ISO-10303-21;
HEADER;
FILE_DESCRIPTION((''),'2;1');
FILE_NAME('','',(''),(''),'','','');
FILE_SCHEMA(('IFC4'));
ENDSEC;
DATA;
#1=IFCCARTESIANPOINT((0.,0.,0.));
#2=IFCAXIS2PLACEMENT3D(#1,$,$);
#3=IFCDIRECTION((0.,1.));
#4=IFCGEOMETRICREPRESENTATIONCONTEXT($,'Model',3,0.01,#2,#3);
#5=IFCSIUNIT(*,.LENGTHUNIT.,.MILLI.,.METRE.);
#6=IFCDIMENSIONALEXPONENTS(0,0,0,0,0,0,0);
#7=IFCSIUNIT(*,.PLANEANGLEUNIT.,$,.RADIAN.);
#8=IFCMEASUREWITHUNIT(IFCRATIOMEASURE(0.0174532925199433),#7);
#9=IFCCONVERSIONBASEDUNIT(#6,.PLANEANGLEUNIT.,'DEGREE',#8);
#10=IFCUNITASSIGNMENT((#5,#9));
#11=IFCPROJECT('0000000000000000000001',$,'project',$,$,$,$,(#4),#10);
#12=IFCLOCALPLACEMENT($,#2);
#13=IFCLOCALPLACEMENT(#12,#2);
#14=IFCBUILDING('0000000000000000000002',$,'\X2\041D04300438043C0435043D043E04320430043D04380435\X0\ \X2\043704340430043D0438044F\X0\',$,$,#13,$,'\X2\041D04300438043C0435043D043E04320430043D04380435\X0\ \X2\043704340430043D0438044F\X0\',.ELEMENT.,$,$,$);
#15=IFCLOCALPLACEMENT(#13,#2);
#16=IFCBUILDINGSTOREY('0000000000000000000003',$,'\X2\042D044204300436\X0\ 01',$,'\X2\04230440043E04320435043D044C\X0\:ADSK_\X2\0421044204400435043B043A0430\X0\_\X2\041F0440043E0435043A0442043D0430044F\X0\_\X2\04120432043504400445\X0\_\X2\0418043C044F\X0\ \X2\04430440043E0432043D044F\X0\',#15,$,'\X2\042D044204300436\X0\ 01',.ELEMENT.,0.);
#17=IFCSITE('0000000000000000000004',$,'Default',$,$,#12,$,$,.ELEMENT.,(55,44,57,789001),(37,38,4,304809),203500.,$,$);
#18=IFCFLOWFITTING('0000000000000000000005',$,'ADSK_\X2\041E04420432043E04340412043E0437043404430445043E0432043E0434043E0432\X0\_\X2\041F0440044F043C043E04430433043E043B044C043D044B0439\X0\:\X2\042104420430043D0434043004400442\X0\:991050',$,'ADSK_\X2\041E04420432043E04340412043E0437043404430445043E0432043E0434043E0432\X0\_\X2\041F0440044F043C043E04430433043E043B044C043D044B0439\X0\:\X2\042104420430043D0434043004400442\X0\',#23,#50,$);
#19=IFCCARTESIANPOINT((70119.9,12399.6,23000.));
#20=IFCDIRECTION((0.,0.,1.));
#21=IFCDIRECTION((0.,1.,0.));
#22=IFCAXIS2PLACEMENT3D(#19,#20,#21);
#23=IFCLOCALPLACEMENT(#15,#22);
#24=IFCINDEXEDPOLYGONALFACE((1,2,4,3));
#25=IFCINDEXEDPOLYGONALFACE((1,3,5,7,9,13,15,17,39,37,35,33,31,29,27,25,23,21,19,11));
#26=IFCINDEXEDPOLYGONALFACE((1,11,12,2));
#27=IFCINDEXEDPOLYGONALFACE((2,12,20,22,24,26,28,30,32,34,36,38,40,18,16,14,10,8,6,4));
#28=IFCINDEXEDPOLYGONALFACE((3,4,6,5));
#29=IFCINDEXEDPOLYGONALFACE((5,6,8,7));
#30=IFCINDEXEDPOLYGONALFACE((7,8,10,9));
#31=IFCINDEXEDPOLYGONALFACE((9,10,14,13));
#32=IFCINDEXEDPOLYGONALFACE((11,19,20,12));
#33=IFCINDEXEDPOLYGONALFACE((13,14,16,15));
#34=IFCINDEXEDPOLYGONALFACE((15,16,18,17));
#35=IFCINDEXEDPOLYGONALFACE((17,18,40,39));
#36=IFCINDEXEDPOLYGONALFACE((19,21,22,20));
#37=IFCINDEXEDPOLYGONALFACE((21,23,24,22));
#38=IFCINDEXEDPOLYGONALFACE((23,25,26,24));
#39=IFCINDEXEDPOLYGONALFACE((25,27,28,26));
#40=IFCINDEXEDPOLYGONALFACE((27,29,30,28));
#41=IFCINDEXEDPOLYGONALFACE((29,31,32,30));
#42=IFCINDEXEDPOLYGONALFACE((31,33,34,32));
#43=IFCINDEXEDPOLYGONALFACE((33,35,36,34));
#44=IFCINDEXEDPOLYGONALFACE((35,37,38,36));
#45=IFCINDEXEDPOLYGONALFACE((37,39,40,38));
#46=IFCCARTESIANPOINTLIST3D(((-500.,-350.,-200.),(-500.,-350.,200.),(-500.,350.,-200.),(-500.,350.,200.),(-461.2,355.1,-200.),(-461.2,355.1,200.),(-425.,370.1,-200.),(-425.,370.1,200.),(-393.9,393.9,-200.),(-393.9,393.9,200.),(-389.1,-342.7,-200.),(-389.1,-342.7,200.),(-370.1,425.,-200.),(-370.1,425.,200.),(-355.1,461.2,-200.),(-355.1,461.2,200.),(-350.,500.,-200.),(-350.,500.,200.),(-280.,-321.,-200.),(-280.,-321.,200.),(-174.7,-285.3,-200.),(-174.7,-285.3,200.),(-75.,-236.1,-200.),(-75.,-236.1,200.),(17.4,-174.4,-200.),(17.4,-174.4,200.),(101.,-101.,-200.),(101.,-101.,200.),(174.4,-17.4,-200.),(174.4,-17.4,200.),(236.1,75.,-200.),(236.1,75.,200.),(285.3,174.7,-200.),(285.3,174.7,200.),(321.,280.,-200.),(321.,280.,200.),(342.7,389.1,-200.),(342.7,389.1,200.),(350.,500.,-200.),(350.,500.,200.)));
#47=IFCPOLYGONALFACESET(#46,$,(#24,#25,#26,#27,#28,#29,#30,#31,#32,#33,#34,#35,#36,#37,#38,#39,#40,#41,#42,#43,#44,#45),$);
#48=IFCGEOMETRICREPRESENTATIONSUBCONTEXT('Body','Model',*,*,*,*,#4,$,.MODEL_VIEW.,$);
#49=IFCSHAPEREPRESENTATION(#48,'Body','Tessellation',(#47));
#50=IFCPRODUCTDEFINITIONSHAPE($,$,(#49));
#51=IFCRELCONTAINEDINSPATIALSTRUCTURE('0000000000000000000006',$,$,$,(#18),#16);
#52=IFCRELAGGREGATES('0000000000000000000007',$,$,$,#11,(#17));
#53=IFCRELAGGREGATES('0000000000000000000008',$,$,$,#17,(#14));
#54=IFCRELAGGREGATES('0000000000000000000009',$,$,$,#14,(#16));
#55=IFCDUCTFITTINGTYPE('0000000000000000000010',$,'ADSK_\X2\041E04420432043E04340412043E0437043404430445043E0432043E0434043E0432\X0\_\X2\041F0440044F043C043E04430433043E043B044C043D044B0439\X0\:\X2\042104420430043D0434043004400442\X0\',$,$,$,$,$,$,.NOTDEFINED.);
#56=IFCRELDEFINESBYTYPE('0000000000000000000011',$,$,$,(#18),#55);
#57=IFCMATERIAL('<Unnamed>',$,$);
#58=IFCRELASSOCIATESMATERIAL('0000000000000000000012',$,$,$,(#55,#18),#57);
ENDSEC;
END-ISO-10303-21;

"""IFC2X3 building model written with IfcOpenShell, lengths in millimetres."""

from ifc_helpers import new_model, entity, si_unit, converted_unit, direction, frame, frame_2d, origin, place, context, subcontext, project, spatial, polyline, circle_curve, parameter, trimmed, segment, composite_curve, outline, extrude, source, transform, mapped, material, type_object, type_shapes, element, save


model = new_model("IFC2X3")

# Units and contexts
model_context = context("Model", 3, precision=0.01, world=origin(), true_north=direction((0.0, 1.0)))
body_context = subcontext(model_context, "Body", "Model", "MODEL_VIEW")
ifc_project = project(units=[si_unit("LENGTHUNIT", "METRE", prefix="MILLI"), converted_unit("PLANEANGLEUNIT", "DEGREE", entity("IfcRatioMeasure", 0.0174532925199433), si_unit("PLANEANGLEUNIT", "RADIAN"), dimensions=[0, 0, 0, 0, 0, 0, 0])], contexts=[model_context])

# Site, building, storey
site_placement = place(None, origin())
site = spatial("IfcSite", under=ifc_project, at=site_placement, Name="Default", CompositionType="ELEMENT", RefLatitude=(55, 44, 57, 789001), RefLongitude=(37, 38, 4, 304809), RefElevation=203500.0)
building_placement = place(site_placement, origin())
building = spatial("IfcBuilding", under=site, at=building_placement, Name="Наименование здания", LongName="Наименование здания", CompositionType="ELEMENT")
storey_placement = place(building_placement, origin())
storey = spatial("IfcBuildingStorey", under=building, at=storey_placement, Name="Этаж 01", ObjectType="Уровень:ADSK_Стрелка_Проектная_Вверх_Имя уровня", LongName="Этаж 01", CompositionType="ELEMENT", Elevation=0.0)

# Shared definitions
ifc_material_1 = material(Name="<Unnamed>")

# Flow fitting
duct_fitting_type_1 = type_object("IfcDuctFittingType", Name="ADSK_ОтводВоздуховодов_Прямоугольный:Стандарт", PredefinedType="NOTDEFINED", material=ifc_material_1)
shared_shape_1 = source(origin(), body_context, "Body", "SweptSolid", [
    extrude(outline(composite_curve([segment(polyline([(-600.0, -250.0), (100.0, -250.0)]), True, "CONTINUOUS"), segment(trimmed(circle_curve(frame_2d((250.0, -250.0), x_axis=(0.0, 1.0)), 150.0), [parameter(0.0)], [parameter(90.0)], True, "PARAMETER"), False, "CONTINUOUS"), segment(polyline([(250.0, -100.0), (250.0, 600.0)]), True, "CONTINUOUS"), segment(trimmed(circle_curve(frame_2d((250.0, -250.0), x_axis=(0.0, 1.0)), 850.0), [parameter(0.0)], [parameter(90.0)], True, "PARAMETER"), True, "CONTINUOUS")], self_intersect=False)), frame((-250.0, 250.0, -200.0), z_axis=(0.0, 0.0, 1.0), x_axis=(-1.0, 0.0, 0.0)), (0.0, 0.0, 1.0), 400.0),
])
type_shapes(duct_fitting_type_1, [shared_shape_1])
flow_fitting_1_placement = place(storey_placement, frame((70119.9, 12399.6, 23000.0), z_axis=(0.0, 0.0, 1.0), x_axis=(0.0, 1.0, 0.0)))
element("IfcFlowFitting", 1, at=flow_fitting_1_placement, inside=storey, type_object=duct_fitting_type_1, material=ifc_material_1, Name="ADSK_ОтводВоздуховодов_Прямоугольный:Стандарт:991050", ObjectType="ADSK_ОтводВоздуховодов_Прямоугольный:Стандарт", context=body_context, shape_type="MappedRepresentation", body=[
    mapped(shared_shape_1, transform((0.0, 0.0, 0.0), scale=1.0)),
])

save(model, "model.ifc")
